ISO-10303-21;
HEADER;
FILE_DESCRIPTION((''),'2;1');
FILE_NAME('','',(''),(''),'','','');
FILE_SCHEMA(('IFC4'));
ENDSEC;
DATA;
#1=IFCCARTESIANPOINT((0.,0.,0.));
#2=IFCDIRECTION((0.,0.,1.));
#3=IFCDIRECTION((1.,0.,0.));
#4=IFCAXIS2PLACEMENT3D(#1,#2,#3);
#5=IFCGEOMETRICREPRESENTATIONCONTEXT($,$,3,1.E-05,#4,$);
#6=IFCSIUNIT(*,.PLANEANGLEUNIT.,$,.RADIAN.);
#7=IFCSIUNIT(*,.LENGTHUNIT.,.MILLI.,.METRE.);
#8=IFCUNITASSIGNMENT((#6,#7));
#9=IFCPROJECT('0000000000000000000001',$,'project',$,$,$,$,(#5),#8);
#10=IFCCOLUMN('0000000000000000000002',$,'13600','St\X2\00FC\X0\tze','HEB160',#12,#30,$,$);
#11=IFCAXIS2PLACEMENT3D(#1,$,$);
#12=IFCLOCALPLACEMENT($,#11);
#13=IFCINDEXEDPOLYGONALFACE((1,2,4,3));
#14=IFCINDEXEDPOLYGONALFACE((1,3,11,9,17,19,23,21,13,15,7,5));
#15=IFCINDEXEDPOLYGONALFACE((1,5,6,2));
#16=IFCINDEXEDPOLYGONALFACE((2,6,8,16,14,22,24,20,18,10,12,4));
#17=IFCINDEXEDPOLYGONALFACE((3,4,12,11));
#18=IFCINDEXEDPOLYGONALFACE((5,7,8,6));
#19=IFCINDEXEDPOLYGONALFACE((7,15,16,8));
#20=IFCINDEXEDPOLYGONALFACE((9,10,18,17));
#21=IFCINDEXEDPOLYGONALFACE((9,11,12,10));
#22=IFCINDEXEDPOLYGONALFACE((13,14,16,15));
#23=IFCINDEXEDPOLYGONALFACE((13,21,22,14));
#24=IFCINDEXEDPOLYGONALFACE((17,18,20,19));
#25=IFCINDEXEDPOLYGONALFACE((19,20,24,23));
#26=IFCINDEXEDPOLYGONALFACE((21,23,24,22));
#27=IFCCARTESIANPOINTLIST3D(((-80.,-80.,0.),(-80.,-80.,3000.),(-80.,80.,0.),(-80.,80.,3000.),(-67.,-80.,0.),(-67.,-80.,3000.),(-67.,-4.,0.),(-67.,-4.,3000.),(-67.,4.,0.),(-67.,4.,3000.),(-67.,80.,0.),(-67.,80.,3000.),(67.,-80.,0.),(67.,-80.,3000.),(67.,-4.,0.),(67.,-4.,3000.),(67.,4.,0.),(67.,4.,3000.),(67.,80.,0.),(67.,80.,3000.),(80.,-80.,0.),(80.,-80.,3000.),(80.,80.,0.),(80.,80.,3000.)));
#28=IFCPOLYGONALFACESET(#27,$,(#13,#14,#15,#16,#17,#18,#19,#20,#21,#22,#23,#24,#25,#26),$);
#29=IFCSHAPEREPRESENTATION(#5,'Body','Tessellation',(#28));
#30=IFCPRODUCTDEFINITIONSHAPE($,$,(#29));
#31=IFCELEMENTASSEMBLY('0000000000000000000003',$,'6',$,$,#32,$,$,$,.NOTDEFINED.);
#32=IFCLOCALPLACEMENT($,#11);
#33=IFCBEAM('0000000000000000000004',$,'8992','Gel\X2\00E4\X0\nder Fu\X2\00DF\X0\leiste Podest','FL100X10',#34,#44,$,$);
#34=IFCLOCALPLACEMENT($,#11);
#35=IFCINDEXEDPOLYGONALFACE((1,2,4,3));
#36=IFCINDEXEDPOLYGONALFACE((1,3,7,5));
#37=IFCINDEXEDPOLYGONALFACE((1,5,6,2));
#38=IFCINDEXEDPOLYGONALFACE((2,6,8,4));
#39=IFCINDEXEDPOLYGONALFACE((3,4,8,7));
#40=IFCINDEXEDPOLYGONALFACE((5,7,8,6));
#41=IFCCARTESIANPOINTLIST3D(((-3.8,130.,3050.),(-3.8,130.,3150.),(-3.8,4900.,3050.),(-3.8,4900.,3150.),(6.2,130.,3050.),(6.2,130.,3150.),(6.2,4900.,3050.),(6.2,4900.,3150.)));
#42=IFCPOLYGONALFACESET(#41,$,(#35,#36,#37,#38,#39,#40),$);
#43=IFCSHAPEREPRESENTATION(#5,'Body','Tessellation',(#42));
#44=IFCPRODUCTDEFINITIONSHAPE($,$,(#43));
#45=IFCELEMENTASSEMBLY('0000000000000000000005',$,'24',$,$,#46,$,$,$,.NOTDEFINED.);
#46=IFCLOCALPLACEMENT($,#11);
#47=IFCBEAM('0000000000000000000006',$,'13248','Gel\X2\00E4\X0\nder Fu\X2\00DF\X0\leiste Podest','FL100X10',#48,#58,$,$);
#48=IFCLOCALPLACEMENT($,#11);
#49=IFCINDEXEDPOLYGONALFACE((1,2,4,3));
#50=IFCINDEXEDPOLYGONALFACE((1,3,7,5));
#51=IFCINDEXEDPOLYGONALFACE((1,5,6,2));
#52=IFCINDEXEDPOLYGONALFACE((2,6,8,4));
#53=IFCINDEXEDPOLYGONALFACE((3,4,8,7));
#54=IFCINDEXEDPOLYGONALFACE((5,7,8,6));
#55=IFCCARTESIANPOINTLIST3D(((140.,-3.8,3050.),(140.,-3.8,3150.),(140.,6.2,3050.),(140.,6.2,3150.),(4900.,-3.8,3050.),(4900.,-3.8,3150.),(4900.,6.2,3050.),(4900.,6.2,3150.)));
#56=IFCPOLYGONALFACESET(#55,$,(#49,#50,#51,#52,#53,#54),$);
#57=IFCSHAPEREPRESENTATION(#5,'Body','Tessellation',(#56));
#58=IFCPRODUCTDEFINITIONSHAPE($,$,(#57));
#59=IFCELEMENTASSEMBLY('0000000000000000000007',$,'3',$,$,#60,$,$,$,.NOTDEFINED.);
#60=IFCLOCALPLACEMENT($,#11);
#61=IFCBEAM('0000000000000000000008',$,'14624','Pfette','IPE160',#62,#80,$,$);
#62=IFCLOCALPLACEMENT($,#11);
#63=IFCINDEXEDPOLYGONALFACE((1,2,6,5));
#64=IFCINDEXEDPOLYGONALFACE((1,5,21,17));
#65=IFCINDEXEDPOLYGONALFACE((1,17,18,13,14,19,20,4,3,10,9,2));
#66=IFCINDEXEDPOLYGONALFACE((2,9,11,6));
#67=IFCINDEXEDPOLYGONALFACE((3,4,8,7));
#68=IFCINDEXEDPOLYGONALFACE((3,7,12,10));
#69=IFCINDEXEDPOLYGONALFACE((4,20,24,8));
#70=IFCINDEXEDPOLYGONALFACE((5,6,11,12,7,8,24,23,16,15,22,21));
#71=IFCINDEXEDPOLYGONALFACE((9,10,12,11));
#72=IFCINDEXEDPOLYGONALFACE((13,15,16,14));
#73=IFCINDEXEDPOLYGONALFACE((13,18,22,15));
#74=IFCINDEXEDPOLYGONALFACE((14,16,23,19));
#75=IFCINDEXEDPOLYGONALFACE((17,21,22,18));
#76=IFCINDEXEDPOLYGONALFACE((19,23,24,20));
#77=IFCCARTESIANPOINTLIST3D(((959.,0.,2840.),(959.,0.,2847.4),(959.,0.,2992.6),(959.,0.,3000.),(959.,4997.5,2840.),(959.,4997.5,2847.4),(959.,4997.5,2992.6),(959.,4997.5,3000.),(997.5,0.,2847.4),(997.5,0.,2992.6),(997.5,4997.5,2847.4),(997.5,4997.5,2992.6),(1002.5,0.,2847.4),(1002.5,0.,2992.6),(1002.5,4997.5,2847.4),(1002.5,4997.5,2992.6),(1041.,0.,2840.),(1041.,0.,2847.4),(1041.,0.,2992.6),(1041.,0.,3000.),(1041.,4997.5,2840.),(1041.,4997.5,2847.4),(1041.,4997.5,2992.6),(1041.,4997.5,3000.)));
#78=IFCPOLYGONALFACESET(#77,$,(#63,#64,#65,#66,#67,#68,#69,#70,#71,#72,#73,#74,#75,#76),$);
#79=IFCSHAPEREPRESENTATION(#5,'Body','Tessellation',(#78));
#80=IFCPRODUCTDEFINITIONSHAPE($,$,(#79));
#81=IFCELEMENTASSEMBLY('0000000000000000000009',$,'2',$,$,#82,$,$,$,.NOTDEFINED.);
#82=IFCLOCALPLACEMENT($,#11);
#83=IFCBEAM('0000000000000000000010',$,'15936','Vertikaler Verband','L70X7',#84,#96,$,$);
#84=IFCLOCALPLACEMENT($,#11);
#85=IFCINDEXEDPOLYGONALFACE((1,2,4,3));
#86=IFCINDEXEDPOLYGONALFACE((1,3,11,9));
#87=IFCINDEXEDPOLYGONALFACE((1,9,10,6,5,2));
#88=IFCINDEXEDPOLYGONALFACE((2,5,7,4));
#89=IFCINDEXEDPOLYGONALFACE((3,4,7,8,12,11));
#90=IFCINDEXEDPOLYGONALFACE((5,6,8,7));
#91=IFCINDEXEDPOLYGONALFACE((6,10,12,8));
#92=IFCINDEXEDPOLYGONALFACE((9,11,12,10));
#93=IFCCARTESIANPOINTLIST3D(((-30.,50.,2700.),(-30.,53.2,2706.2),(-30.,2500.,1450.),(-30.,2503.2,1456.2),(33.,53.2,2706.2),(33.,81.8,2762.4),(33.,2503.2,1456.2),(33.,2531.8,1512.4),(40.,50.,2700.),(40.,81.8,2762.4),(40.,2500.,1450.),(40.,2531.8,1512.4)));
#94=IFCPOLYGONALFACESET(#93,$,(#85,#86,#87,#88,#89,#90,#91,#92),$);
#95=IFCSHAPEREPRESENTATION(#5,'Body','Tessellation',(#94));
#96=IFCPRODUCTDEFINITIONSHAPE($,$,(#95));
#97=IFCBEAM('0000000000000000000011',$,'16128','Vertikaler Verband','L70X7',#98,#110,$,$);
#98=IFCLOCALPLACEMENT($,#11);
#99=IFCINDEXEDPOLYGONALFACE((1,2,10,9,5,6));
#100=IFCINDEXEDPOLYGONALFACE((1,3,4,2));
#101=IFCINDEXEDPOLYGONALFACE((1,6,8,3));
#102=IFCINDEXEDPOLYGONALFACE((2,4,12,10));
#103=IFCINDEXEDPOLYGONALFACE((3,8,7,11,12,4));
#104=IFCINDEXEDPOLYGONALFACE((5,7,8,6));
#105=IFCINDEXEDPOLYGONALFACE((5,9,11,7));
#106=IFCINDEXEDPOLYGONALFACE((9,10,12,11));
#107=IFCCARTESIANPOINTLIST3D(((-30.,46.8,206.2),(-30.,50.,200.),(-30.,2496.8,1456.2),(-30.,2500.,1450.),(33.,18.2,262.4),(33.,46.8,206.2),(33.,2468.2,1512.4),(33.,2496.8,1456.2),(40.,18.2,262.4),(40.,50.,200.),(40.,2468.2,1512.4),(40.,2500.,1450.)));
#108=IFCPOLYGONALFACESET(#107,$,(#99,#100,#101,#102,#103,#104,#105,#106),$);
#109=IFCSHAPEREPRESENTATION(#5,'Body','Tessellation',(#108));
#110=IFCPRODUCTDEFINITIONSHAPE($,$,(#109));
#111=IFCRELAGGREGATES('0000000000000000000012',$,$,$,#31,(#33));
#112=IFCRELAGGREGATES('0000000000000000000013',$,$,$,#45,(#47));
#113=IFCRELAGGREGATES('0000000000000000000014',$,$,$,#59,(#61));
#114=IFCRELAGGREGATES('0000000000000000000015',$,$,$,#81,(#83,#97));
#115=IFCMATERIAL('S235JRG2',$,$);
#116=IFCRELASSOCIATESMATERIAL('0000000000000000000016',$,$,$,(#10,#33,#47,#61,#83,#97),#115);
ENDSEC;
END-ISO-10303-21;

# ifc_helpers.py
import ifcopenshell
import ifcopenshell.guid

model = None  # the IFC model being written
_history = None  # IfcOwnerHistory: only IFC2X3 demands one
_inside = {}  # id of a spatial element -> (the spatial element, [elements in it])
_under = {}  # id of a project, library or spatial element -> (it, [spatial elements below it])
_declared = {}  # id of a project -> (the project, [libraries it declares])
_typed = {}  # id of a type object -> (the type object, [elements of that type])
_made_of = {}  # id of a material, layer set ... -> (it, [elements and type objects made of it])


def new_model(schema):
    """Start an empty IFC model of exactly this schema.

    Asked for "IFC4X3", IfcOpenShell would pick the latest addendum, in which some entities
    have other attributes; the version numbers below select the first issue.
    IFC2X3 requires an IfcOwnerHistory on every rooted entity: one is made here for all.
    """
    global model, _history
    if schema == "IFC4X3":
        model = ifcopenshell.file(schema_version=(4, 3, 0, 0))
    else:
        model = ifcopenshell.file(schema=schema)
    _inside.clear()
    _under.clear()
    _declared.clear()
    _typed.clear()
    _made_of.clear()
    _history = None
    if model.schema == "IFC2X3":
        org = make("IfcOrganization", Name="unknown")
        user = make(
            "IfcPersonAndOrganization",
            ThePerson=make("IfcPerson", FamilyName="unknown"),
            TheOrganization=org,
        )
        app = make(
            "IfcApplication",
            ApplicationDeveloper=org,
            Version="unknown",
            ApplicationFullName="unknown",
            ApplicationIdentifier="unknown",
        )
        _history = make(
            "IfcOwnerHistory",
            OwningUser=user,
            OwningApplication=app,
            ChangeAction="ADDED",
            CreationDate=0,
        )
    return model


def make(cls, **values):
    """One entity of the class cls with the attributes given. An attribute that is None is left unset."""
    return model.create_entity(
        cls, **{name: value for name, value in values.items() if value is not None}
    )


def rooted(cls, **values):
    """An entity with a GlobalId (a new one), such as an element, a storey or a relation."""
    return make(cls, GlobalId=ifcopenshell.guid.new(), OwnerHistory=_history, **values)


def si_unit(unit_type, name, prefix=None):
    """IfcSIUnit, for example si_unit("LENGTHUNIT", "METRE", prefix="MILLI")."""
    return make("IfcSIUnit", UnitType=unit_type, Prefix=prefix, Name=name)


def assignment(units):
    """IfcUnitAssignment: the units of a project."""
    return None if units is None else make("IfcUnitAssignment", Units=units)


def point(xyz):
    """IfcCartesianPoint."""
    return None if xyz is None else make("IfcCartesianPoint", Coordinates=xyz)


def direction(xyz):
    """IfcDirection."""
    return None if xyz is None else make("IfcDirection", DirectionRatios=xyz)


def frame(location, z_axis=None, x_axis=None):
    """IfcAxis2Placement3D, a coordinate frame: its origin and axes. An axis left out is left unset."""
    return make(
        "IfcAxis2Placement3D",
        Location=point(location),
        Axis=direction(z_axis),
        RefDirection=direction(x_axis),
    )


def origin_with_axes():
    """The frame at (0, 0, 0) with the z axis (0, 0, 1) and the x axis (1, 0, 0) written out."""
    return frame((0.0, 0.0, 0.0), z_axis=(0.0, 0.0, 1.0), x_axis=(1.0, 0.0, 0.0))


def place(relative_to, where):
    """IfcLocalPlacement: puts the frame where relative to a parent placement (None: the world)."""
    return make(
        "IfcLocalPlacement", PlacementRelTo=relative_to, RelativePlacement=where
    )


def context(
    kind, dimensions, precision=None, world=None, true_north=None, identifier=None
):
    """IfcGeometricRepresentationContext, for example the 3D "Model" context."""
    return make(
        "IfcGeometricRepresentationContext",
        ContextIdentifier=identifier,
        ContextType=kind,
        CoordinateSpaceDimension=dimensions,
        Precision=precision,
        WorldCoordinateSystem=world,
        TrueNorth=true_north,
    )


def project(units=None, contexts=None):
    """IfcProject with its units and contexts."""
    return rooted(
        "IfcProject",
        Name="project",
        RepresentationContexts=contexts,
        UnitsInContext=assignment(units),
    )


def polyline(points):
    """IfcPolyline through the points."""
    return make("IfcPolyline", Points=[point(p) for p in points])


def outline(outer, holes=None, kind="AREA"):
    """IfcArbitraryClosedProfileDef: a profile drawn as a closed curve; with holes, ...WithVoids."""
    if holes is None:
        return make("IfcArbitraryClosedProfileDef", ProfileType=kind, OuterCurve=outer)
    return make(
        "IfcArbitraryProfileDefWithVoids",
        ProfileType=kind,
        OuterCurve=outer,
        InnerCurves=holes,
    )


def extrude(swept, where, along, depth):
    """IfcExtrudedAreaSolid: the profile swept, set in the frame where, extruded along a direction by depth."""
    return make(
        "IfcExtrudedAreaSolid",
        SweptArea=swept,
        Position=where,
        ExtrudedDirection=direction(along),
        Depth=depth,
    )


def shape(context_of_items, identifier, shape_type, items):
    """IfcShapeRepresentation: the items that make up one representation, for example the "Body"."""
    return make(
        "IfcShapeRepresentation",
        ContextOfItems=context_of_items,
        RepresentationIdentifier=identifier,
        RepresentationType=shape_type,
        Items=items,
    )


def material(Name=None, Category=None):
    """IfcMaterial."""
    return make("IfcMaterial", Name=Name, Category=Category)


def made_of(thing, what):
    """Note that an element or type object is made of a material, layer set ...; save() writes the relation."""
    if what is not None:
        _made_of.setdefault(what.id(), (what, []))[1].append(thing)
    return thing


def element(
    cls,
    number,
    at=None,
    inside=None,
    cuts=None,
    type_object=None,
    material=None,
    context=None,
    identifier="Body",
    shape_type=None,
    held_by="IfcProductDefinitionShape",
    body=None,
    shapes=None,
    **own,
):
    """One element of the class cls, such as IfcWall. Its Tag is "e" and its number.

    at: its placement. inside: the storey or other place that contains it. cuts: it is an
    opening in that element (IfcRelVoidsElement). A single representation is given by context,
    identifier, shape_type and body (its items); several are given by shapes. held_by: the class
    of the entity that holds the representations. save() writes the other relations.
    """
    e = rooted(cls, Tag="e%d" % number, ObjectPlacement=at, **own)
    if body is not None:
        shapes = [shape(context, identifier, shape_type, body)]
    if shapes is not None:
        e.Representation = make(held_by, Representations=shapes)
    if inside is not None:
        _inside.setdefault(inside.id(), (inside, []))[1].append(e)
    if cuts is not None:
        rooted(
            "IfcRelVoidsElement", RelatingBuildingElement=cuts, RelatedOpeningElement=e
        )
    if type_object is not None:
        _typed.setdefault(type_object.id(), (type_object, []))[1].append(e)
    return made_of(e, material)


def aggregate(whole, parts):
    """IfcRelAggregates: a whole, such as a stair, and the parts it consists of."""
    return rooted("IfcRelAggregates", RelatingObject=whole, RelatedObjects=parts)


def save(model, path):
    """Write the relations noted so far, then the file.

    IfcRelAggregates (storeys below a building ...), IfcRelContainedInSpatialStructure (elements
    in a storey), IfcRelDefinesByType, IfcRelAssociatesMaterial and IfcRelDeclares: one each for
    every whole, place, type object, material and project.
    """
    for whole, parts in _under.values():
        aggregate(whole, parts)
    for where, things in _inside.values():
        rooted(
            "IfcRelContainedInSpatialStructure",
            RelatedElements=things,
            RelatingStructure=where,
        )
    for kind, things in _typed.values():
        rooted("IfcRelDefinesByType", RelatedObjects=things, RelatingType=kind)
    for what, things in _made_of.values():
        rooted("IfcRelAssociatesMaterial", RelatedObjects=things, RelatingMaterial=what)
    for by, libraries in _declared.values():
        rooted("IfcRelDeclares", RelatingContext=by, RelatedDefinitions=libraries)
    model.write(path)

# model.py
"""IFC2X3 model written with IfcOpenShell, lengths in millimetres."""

from ifc_helpers import new_model, si_unit, frame, origin_with_axes, place, context, project, polyline, outline, extrude, material, element, aggregate, save


model = new_model("IFC2X3")

# Units and contexts
context_of_model = context(None, 3, precision=1e-05, world=origin_with_axes())
ifc_project = project(units=[si_unit("PLANEANGLEUNIT", "RADIAN"), si_unit("LENGTHUNIT", "METRE", prefix="MILLI")], contexts=[context_of_model])

# Column
ifc_material = material(Name="S235JRG2")
placement_1 = place(None, frame((0.0, 0.0, 3000.0), z_axis=(-1.0, 0.0, 0.0), x_axis=(0.0, 0.0, -1.0)))
column_placement = place(placement_1, origin_with_axes())
element("IfcColumn", 1, at=column_placement, material=ifc_material, Name="13600", Description="Stütze", ObjectType="HEB160", context=context_of_model, shape_type="SweptSolid", body=[
    extrude(outline(polyline([(80.0, -80.0), (80.0, -67.0), (4.0, -67.0), (4.0, 67.0), (80.0, 67.0), (80.0, 80.0), (-80.0, 80.0), (-80.0, 67.0), (-4.0, 67.0), (-4.0, -67.0), (-80.0, -67.0), (-80.0, -80.0), (80.0, -80.0), (80.0, -80.0)])), frame((0.0, 0.0, 0.0), z_axis=(1.0, 0.0, 0.0), x_axis=(0.0, 1.0, 0.0)), (0.0, 0.0, 1.0), 3000.0),
])

# Element assemblies, beams
assembly_1_placement = place(None, frame((1.2, 5130.0, 6100.0), z_axis=(0.0, 0.0, 1.0), x_axis=(0.0, 1.0, 0.0)))
assembly_1 = element("IfcElementAssembly", 2, at=assembly_1_placement, Name="6", PredefinedType="NOTDEFINED")
placement_2 = place(None, frame((1.2, 130.0, 3100.0), z_axis=(0.0, 0.0, 1.0), x_axis=(0.0, 1.0, 0.0)))
beam_1_placement = place(placement_2, origin_with_axes())
beam_1 = element("IfcBeam", 3, at=beam_1_placement, material=ifc_material, Name="8992", Description="Geländer Fußleiste Podest", ObjectType="FL100X10", context=context_of_model, shape_type="SweptSolid", body=[
    extrude(outline(polyline([(5.0, -50.0), (5.0, 50.0), (-5.0, 50.0), (-5.0, -50.0), (5.0, -50.0), (5.0, -50.0)])), frame((0.0, 0.0, 0.0), z_axis=(1.0, 0.0, 0.0), x_axis=(0.0, 1.0, 0.0)), (0.0, 0.0, 1.0), 4770.0),
])
aggregate(assembly_1, [beam_1])
assembly_2_placement = place(None, frame((140.0, 9998.8, 6100.0), z_axis=(0.0, 0.0, 1.0), x_axis=(1.0, 0.0, 0.0)))
assembly_2 = element("IfcElementAssembly", 4, at=assembly_2_placement, Name="24", PredefinedType="NOTDEFINED")
placement_3 = place(None, frame((140.0, 1.2, 3100.0), z_axis=(0.0, 0.0, 1.0), x_axis=(1.0, 0.0, 0.0)))
beam_2_placement = place(placement_3, origin_with_axes())
beam_2 = element("IfcBeam", 5, at=beam_2_placement, material=ifc_material, Name="13248", Description="Geländer Fußleiste Podest", ObjectType="FL100X10", context=context_of_model, shape_type="SweptSolid", body=[
    extrude(outline(polyline([(5.0, -50.0), (5.0, 50.0), (-5.0, 50.0), (-5.0, -50.0), (5.0, -50.0), (5.0, -50.0)])), frame((0.0, 0.0, 0.0), z_axis=(1.0, 0.0, 0.0), x_axis=(0.0, 1.0, 0.0)), (0.0, 0.0, 1.0), 4760.0),
])
aggregate(assembly_2, [beam_2])

# Element assembly, beam
assembly_3_placement = place(None, frame((1000.0, 5002.5, 6000.0), z_axis=(0.0, 0.0, 1.0), x_axis=(0.0, 1.0, 0.0)))
assembly_3 = element("IfcElementAssembly", 6, at=assembly_3_placement, Name="3", PredefinedType="NOTDEFINED")
placement_4 = place(None, frame((1000.0, 0.0, 2920.0), z_axis=(0.0, 0.0, 1.0), x_axis=(0.0, 1.0, 0.0)))
beam_3_placement = place(placement_4, origin_with_axes())
beam_3 = element("IfcBeam", 7, at=beam_3_placement, material=ifc_material, Name="14624", Description="Pfette", ObjectType="IPE160", context=context_of_model, shape_type="SweptSolid", body=[
    extrude(outline(polyline([(41.0, -80.0), (41.0, -72.6), (2.5, -72.6), (2.5, 72.6), (41.0, 72.6), (41.0, 80.0), (-41.0, 80.0), (-41.0, 72.6), (-2.5, 72.6), (-2.5, -72.6), (-41.0, -72.6), (-41.0, -80.0), (41.0, -80.0), (41.0, -80.0)])), frame((0.0, 0.0, 0.0), z_axis=(1.0, 0.0, 0.0), x_axis=(0.0, 1.0, 0.0)), (0.0, 0.0, 1.0), 4997.5),
])
aggregate(assembly_3, [beam_3])

# Element assembly, beams
assembly_4_placement = place(None, frame((40.0, 7500.0, 1450.0), z_axis=(0.0, 0.45447, 0.890762), x_axis=(0.0, 0.890762, -0.45447)))
assembly_4 = element("IfcElementAssembly", 8, at=assembly_4_placement, Name="2", PredefinedType="NOTDEFINED")
placement_5 = place(None, frame((20.3, 59.0, 2717.5), z_axis=(0.0, 0.45447, 0.890762), x_axis=(0.0, 0.890762, -0.45447)))
beam_4_placement = place(placement_5, origin_with_axes())
beam_4 = element("IfcBeam", 9, at=beam_4_placement, material=ifc_material, Name="15936", Description="Vertikaler Verband", ObjectType="L70X7", context=context_of_model, shape_type="SweptSolid", body=[
    extrude(outline(polyline([(-19.7, 50.3), (-19.7, -19.7), (50.3, -19.7), (50.3, -12.7), (-12.7, -12.7), (-12.7, 50.3), (-19.7, 50.3), (-19.7, 50.3)])), frame((0.0, 0.0, 0.0), z_axis=(1.0, 0.0, 0.0), x_axis=(0.0, 1.0, 0.0)), (0.0, 0.0, 1.0), 2750.5),
])
placement_6 = place(None, frame((20.3, 41.0, 217.5), z_axis=(0.0, -0.45447, 0.890762), x_axis=(0.0, 0.890762, 0.45447)))
beam_5_placement = place(placement_6, origin_with_axes())
beam_5 = element("IfcBeam", 10, at=beam_5_placement, material=ifc_material, Name="16128", Description="Vertikaler Verband", ObjectType="L70X7", context=context_of_model, shape_type="SweptSolid", body=[
    extrude(outline(polyline([(-19.7, 50.3), (-19.7, -19.7), (50.3, -19.7), (50.3, -12.7), (-12.7, -12.7), (-12.7, 50.3), (-19.7, 50.3), (-19.7, 50.3)])), frame((0.0, 0.0, 0.0), z_axis=(1.0, 0.0, 0.0), x_axis=(0.0, 1.0, 0.0)), (0.0, 0.0, 1.0), 2750.5),
])
aggregate(assembly_4, [beam_4, beam_5])

save(model, "model.ifc")
